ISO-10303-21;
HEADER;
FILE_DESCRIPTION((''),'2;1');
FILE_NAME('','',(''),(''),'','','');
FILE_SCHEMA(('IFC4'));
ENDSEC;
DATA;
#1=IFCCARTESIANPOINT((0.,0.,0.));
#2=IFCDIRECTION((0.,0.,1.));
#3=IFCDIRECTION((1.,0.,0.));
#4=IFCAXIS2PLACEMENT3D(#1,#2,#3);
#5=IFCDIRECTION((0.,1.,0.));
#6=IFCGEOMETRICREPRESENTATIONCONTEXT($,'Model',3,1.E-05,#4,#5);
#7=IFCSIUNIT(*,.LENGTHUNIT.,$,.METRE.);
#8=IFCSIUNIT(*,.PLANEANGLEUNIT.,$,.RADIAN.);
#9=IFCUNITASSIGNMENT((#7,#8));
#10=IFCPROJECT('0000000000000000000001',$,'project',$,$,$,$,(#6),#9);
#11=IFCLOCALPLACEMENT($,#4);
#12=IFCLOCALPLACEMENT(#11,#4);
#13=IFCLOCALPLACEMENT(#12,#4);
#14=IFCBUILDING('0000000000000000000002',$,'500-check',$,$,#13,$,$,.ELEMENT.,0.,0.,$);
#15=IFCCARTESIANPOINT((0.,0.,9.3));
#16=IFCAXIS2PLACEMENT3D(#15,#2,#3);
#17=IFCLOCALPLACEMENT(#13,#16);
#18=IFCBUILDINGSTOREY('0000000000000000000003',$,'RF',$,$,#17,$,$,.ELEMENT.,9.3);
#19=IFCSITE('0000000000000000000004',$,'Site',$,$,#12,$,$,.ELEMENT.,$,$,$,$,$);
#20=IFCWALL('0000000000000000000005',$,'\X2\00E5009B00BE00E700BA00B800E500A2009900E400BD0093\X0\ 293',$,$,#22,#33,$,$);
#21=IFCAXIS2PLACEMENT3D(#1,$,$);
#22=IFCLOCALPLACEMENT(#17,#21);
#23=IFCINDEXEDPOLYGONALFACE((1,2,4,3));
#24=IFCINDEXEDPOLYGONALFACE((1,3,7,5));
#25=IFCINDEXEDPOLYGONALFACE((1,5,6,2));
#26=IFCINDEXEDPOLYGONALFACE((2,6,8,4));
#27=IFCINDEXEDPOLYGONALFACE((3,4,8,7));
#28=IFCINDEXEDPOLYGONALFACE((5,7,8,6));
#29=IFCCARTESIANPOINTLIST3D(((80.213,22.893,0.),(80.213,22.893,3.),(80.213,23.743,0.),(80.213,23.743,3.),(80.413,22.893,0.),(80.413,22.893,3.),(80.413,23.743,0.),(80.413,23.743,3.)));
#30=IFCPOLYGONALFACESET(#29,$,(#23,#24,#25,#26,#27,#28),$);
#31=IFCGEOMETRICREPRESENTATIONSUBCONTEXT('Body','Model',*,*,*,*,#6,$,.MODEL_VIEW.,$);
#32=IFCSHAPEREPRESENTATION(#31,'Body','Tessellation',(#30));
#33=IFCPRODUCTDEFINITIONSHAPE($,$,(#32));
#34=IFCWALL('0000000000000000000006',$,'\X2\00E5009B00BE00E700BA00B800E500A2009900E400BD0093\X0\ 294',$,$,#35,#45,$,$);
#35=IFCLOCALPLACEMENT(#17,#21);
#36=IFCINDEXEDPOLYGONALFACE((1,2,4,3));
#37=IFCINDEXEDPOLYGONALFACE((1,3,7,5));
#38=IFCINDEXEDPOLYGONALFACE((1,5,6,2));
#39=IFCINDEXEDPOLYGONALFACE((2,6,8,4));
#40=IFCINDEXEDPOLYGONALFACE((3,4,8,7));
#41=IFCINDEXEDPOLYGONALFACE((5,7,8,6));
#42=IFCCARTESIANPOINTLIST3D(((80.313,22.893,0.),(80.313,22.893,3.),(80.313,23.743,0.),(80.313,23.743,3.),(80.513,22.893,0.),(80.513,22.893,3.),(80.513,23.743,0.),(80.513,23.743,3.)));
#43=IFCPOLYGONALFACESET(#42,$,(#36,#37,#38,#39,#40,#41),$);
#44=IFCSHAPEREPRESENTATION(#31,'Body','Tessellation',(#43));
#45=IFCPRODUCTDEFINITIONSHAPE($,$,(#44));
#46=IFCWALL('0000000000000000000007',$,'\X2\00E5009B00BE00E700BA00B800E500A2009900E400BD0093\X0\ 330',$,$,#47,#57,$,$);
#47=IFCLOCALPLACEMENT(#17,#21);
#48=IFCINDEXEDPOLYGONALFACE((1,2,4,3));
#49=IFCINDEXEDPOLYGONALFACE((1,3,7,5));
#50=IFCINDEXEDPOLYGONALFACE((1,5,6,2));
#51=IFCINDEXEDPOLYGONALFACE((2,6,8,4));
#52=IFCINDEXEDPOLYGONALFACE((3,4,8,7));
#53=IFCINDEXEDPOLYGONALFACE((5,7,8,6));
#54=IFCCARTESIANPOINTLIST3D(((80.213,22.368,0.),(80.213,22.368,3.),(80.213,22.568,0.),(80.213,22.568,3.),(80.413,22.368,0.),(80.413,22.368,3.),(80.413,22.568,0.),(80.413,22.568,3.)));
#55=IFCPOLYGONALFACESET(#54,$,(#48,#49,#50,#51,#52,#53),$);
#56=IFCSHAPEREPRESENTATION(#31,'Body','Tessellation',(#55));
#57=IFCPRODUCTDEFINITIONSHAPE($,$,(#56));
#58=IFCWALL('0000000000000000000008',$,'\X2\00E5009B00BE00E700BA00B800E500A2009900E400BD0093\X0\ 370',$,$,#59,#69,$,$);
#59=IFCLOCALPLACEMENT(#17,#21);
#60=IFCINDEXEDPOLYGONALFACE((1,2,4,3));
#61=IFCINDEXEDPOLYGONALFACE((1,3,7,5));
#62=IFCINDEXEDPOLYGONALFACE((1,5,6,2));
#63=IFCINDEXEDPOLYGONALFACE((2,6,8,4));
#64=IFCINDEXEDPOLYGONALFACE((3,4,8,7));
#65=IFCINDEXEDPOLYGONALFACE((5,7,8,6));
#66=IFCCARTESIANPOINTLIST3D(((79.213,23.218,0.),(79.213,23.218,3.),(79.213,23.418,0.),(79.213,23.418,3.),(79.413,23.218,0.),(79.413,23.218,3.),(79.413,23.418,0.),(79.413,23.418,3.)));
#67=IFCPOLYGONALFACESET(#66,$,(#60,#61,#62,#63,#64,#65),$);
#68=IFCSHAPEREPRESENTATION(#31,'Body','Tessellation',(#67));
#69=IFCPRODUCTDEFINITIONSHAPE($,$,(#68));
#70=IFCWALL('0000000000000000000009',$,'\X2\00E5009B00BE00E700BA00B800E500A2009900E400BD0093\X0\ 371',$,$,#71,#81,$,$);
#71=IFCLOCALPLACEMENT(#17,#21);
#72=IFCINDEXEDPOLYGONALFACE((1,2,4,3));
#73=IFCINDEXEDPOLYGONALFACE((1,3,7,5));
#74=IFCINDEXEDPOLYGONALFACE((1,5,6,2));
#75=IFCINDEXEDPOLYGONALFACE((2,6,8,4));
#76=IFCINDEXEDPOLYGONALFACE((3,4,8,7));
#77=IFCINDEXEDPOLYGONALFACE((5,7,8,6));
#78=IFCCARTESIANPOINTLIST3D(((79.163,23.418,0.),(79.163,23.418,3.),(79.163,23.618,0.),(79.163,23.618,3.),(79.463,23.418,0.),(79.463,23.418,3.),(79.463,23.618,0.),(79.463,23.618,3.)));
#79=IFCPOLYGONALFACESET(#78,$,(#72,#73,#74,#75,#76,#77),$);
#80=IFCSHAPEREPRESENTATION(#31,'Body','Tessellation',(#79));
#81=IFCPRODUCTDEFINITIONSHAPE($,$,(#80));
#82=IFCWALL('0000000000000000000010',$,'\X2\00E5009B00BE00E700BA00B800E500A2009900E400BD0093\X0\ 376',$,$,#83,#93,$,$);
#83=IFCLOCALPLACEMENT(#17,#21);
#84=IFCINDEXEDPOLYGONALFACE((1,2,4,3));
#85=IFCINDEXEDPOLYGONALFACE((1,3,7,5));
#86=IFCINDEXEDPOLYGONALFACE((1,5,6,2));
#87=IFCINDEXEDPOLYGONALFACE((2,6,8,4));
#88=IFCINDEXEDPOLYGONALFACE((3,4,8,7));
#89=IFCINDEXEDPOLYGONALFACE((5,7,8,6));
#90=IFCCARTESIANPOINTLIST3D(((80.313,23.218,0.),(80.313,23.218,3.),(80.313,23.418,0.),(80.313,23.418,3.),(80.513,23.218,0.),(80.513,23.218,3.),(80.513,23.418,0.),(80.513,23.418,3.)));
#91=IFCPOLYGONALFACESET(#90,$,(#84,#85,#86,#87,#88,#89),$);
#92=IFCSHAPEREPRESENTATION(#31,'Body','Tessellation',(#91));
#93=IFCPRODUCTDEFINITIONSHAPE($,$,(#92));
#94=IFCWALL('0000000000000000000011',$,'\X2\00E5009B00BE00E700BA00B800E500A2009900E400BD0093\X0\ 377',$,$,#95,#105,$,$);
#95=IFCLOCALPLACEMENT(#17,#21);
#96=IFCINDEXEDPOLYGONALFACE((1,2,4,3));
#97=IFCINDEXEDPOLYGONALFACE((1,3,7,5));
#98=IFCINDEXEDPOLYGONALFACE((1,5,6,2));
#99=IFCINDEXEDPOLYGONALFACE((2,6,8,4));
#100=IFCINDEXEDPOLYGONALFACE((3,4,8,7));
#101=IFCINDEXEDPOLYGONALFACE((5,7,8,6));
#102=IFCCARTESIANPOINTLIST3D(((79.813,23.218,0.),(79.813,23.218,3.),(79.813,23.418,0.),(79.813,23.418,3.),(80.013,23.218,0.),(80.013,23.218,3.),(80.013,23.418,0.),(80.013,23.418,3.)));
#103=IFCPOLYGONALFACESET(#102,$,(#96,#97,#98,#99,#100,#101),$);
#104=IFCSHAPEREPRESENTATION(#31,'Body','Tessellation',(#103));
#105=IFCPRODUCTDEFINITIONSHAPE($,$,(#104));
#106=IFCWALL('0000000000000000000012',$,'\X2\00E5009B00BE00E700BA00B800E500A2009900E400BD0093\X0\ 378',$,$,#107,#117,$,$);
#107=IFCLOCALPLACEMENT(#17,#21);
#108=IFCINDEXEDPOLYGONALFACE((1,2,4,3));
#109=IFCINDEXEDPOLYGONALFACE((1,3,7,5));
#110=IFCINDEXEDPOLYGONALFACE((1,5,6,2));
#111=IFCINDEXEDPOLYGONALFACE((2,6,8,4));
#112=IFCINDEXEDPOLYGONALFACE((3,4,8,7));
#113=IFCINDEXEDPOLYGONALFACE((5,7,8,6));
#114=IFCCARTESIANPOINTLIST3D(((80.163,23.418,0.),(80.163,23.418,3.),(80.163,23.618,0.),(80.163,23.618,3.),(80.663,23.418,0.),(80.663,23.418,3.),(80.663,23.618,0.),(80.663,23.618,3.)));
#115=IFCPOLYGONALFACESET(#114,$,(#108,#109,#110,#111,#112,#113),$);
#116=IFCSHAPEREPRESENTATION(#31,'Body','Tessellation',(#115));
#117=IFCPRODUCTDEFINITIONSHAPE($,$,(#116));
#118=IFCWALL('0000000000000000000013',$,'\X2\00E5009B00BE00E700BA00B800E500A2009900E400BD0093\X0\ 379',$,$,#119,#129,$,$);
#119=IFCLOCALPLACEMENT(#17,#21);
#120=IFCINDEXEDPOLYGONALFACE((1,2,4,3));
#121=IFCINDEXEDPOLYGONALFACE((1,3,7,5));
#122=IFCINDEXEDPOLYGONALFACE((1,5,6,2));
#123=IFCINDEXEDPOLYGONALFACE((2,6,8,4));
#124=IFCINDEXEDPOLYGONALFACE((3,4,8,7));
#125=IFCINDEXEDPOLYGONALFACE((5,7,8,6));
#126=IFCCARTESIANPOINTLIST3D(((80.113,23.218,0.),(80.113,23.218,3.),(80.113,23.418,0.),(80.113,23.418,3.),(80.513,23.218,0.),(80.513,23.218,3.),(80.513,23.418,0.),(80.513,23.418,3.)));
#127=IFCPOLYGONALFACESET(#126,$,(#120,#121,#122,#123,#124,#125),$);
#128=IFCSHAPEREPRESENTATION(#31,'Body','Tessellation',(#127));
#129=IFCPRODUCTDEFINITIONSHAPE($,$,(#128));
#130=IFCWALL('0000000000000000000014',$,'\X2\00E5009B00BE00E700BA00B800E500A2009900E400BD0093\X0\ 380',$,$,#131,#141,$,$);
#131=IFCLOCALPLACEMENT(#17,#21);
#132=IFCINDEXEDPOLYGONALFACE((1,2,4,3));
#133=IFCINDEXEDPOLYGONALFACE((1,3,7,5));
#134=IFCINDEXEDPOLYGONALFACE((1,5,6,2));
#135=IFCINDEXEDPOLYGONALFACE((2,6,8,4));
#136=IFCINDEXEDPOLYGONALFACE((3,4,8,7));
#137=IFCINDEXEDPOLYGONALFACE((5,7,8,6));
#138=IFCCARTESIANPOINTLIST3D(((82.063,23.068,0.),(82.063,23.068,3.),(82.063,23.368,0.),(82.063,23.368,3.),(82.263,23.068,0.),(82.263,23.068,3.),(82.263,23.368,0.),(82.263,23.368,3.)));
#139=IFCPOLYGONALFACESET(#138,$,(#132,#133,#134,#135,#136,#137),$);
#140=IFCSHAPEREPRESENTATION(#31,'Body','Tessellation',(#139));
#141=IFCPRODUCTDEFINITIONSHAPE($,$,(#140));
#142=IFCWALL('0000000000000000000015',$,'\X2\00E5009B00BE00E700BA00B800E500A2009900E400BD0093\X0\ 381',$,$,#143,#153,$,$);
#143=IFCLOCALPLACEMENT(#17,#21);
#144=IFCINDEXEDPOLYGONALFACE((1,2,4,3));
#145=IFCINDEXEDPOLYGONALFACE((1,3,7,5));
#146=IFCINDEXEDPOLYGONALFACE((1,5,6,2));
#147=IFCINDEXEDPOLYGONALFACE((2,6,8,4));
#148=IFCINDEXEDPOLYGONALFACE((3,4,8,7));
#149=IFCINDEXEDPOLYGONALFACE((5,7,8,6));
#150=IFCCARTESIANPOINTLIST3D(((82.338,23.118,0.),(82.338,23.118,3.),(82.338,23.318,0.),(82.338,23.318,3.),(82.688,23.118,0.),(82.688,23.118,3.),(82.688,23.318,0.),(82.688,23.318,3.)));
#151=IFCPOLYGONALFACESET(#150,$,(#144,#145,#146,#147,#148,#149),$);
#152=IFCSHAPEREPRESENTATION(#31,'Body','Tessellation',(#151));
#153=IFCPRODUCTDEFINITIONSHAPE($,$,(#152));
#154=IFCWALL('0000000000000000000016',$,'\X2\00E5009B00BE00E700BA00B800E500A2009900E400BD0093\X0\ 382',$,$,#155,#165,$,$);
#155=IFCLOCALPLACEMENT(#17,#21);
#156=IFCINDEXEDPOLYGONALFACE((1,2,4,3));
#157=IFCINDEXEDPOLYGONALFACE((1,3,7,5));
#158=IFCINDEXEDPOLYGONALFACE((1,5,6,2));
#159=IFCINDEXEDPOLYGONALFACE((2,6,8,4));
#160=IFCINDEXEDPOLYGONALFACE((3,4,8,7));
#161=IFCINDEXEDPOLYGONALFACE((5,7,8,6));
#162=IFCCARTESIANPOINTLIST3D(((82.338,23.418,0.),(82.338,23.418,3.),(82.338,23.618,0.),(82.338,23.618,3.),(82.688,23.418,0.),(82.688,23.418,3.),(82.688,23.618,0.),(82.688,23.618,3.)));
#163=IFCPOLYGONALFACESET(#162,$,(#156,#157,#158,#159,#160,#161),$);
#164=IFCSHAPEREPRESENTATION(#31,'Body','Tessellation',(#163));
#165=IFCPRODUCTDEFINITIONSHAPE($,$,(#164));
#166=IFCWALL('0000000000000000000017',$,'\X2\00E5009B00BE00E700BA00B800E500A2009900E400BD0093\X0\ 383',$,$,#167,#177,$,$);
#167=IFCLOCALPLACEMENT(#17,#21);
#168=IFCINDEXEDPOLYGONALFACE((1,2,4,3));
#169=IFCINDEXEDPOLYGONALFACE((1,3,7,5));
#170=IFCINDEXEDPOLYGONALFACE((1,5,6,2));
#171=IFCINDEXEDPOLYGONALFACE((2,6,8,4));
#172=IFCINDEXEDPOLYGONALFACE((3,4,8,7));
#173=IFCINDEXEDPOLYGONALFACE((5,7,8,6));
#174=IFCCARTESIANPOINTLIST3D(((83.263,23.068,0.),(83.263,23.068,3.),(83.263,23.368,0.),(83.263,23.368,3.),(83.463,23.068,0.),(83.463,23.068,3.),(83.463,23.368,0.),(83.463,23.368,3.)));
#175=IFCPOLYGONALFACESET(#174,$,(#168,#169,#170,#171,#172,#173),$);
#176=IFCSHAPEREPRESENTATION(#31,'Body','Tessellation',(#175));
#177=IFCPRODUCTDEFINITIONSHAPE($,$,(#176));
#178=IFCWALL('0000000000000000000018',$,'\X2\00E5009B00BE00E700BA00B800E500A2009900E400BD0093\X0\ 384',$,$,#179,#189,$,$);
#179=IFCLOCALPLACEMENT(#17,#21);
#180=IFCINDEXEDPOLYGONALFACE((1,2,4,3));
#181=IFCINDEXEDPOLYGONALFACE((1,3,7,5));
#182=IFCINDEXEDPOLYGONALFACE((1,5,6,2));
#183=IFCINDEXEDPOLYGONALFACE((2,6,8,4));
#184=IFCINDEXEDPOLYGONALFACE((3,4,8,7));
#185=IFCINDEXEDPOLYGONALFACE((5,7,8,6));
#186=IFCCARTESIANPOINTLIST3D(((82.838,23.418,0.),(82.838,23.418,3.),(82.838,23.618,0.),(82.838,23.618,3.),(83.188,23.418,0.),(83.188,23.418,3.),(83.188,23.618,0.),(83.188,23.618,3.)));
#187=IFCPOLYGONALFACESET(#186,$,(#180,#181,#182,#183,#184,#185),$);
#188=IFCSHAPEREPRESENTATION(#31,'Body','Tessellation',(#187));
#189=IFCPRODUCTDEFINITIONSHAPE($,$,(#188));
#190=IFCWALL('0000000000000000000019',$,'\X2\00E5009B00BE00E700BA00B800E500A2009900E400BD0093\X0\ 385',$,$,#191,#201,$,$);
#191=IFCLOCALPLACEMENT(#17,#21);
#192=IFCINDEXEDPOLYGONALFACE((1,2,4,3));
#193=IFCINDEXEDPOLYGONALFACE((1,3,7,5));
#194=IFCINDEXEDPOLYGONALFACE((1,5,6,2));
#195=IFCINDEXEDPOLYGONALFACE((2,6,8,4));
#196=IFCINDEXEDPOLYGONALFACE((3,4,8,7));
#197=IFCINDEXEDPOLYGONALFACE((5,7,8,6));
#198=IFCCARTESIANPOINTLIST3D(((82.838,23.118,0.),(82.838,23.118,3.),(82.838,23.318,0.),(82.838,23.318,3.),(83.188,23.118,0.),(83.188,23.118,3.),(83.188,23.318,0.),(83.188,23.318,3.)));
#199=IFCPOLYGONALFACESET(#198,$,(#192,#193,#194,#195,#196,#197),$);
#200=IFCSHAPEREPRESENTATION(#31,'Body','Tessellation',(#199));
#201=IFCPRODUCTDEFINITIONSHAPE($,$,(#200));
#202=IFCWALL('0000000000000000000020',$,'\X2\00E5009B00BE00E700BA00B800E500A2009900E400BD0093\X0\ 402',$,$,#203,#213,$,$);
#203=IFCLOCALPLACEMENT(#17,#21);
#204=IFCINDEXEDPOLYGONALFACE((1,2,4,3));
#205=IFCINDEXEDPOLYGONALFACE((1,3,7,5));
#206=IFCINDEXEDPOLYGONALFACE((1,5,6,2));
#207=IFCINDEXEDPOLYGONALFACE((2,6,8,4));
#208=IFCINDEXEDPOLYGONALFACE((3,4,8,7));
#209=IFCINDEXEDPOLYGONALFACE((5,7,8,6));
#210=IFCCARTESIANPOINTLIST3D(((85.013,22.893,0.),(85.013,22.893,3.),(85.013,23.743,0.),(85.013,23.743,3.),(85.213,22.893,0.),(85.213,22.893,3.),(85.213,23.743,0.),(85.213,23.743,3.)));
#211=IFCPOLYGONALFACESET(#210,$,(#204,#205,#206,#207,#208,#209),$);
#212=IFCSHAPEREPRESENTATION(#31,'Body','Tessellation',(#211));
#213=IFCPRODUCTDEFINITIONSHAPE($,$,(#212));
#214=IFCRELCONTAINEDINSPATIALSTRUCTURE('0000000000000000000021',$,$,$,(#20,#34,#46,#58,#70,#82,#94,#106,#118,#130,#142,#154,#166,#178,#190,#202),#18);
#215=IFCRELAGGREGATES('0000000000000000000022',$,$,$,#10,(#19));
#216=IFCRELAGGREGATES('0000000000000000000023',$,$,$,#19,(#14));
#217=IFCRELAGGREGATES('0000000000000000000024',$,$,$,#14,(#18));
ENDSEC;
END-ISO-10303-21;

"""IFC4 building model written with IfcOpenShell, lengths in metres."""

from ifc_helpers import new_model, si_unit, direction, frame, frame_2d, origin_with_axes, place, context, subcontext, project, spatial, rectangle, extrude, element, save


model = new_model("IFC4")

# Units and contexts
model_context = context("Model", 3, precision=1e-05, world=origin_with_axes(), true_north=direction((0.0, 1.0, 0.0)))
body_context = subcontext(model_context, "Body", "Model", "MODEL_VIEW")
ifc_project = project(units=[si_unit("LENGTHUNIT", "METRE"), si_unit("PLANEANGLEUNIT", "RADIAN")], contexts=[model_context])

# Site, building, storey
placement = place(None, origin_with_axes())
site_placement = place(placement, origin_with_axes())
site = spatial("IfcSite", under=ifc_project, at=site_placement, Name="Site", CompositionType="ELEMENT")
building_placement = place(site_placement, origin_with_axes())
building = spatial("IfcBuilding", under=site, at=building_placement, Name="500-check", CompositionType="ELEMENT", ElevationOfRefHeight=0.0, ElevationOfTerrain=0.0)
storey_placement = place(building_placement, frame((0.0, 0.0, 9.3), z_axis=(0.0, 0.0, 1.0), x_axis=(1.0, 0.0, 0.0)))
storey = spatial("IfcBuildingStorey", under=building, at=storey_placement, Name="RF", CompositionType="ELEMENT", Elevation=9.3)

# Walls
for number, where, z_axis, x_axis, name in (
    (1, (80.313, 23.318, 0.0), (0.0, 0.0, 1.0), (0.0, -1.0, 0.0), "å\u009b¾çº¸å¢\u0099ä½\u0093 293"),
    (2, (80.413, 23.318, 0.0), (0.0, 0.0, 1.0), (0.0, -1.0, 0.0), "å\u009b¾çº¸å¢\u0099ä½\u0093 294"),
):
    element("IfcWall", number, at=place(storey_placement, frame(where, z_axis=z_axis, x_axis=x_axis)), inside=storey, Name=name, context=body_context, shape_type="SweptSolid", body=[
        extrude(rectangle(XDim=0.85, YDim=0.2, at=frame_2d((0.0, 0.0), x_axis=(1.0, 0.0, 0.0))), frame((0.0, 0.0, 0.0), z_axis=(0.0, 0.0, 1.0)), (0.0, 0.0, 1.0), 3.0),
    ])
for number, where, z_axis, x_axis, name in (
    (3, (80.313, 22.468, 0.0), (0.0, 0.0, 1.0), (1.0, 0.0, 0.0), "å\u009b¾çº¸å¢\u0099ä½\u0093 330"),
    (4, (79.313, 23.318, 0.0), (0.0, 0.0, 1.0), (-1.0, 0.0, 0.0), "å\u009b¾çº¸å¢\u0099ä½\u0093 370"),
):
    element("IfcWall", number, at=place(storey_placement, frame(where, z_axis=z_axis, x_axis=x_axis)), inside=storey, Name=name, context=body_context, shape_type="SweptSolid", body=[
        extrude(rectangle(XDim=0.2, YDim=0.2, at=frame_2d((0.0, 0.0), x_axis=(1.0, 0.0, 0.0))), frame((0.0, 0.0, 0.0), z_axis=(0.0, 0.0, 1.0)), (0.0, 0.0, 1.0), 3.0),
    ])
wall_1_placement = place(storey_placement, frame((79.313, 23.518, 0.0), z_axis=(0.0, 0.0, 1.0), x_axis=(-1.0, 0.0, 0.0)))
element("IfcWall", 5, at=wall_1_placement, inside=storey, Name="å\u009b¾çº¸å¢\u0099ä½\u0093 371", context=body_context, shape_type="SweptSolid", body=[
    extrude(rectangle(XDim=0.3, YDim=0.2, at=frame_2d((0.0, 0.0), x_axis=(1.0, 0.0, 0.0))), frame((0.0, 0.0, 0.0), z_axis=(0.0, 0.0, 1.0)), (0.0, 0.0, 1.0), 3.0),
])
for number, where, z_axis, x_axis, name in (
    (6, (80.413, 23.318, 0.0), (0.0, 0.0, 1.0), (0.0, 1.0, 0.0), "å\u009b¾çº¸å¢\u0099ä½\u0093 376"),
    (7, (79.913, 23.318, 0.0), (0.0, 0.0, 1.0), (0.0, 1.0, 0.0), "å\u009b¾çº¸å¢\u0099ä½\u0093 377"),
):
    element("IfcWall", number, at=place(storey_placement, frame(where, z_axis=z_axis, x_axis=x_axis)), inside=storey, Name=name, context=body_context, shape_type="SweptSolid", body=[
        extrude(rectangle(XDim=0.2, YDim=0.2, at=frame_2d((0.0, 0.0), x_axis=(1.0, 0.0, 0.0))), frame((0.0, 0.0, 0.0), z_axis=(0.0, 0.0, 1.0)), (0.0, 0.0, 1.0), 3.0),
    ])
wall_2_placement = place(storey_placement, frame((80.413, 23.518, 0.0), z_axis=(0.0, 0.0, 1.0), x_axis=(-1.0, 0.0, 0.0)))
element("IfcWall", 8, at=wall_2_placement, inside=storey, Name="å\u009b¾çº¸å¢\u0099ä½\u0093 378", context=body_context, shape_type="SweptSolid", body=[
    extrude(rectangle(XDim=0.5, YDim=0.2, at=frame_2d((0.0, 0.0), x_axis=(1.0, 0.0, 0.0))), frame((0.0, 0.0, 0.0), z_axis=(0.0, 0.0, 1.0)), (0.0, 0.0, 1.0), 3.0),
])
wall_3_placement = place(storey_placement, frame((80.313, 23.318, 0.0), z_axis=(0.0, 0.0, 1.0), x_axis=(-1.0, 0.0, 0.0)))
element("IfcWall", 9, at=wall_3_placement, inside=storey, Name="å\u009b¾çº¸å¢\u0099ä½\u0093 379", context=body_context, shape_type="SweptSolid", body=[
    extrude(rectangle(XDim=0.4, YDim=0.2, at=frame_2d((0.0, 0.0), x_axis=(1.0, 0.0, 0.0))), frame((0.0, 0.0, 0.0), z_axis=(0.0, 0.0, 1.0)), (0.0, 0.0, 1.0), 3.0),
])
wall_4_placement = place(storey_placement, frame((82.163, 23.218, 0.0), z_axis=(0.0, 0.0, 1.0), x_axis=(0.0, 1.0, 0.0)))
element("IfcWall", 10, at=wall_4_placement, inside=storey, Name="å\u009b¾çº¸å¢\u0099ä½\u0093 380", context=body_context, shape_type="SweptSolid", body=[
    extrude(rectangle(XDim=0.3, YDim=0.2, at=frame_2d((0.0, 0.0), x_axis=(1.0, 0.0, 0.0))), frame((0.0, 0.0, 0.0), z_axis=(0.0, 0.0, 1.0)), (0.0, 0.0, 1.0), 3.0),
])
for number, where, z_axis, x_axis, name in (
    (11, (82.513, 23.218, 0.0), (0.0, 0.0, 1.0), (-1.0, 0.0, 0.0), "å\u009b¾çº¸å¢\u0099ä½\u0093 381"),
    (12, (82.513, 23.518, 0.0), (0.0, 0.0, 1.0), (-1.0, 0.0, 0.0), "å\u009b¾çº¸å¢\u0099ä½\u0093 382"),
):
    element("IfcWall", number, at=place(storey_placement, frame(where, z_axis=z_axis, x_axis=x_axis)), inside=storey, Name=name, context=body_context, shape_type="SweptSolid", body=[
        extrude(rectangle(XDim=0.35, YDim=0.2, at=frame_2d((0.0, 0.0), x_axis=(1.0, 0.0, 0.0))), frame((0.0, 0.0, 0.0), z_axis=(0.0, 0.0, 1.0)), (0.0, 0.0, 1.0), 3.0),
    ])
wall_5_placement = place(storey_placement, frame((83.363, 23.218, 0.0), z_axis=(0.0, 0.0, 1.0), x_axis=(0.0, 1.0, 0.0)))
element("IfcWall", 13, at=wall_5_placement, inside=storey, Name="å\u009b¾çº¸å¢\u0099ä½\u0093 383", context=body_context, shape_type="SweptSolid", body=[
    extrude(rectangle(XDim=0.3, YDim=0.2, at=frame_2d((0.0, 0.0), x_axis=(1.0, 0.0, 0.0))), frame((0.0, 0.0, 0.0), z_axis=(0.0, 0.0, 1.0)), (0.0, 0.0, 1.0), 3.0),
])
for number, where, z_axis, x_axis, name in (
    (14, (83.013, 23.518, 0.0), (0.0, 0.0, 1.0), (1.0, 0.0, 0.0), "å\u009b¾çº¸å¢\u0099ä½\u0093 384"),
    (15, (83.013, 23.218, 0.0), (0.0, 0.0, 1.0), (1.0, 0.0, 0.0), "å\u009b¾çº¸å¢\u0099ä½\u0093 385"),
):
    element("IfcWall", number, at=place(storey_placement, frame(where, z_axis=z_axis, x_axis=x_axis)), inside=storey, Name=name, context=body_context, shape_type="SweptSolid", body=[
        extrude(rectangle(XDim=0.35, YDim=0.2, at=frame_2d((0.0, 0.0), x_axis=(1.0, 0.0, 0.0))), frame((0.0, 0.0, 0.0), z_axis=(0.0, 0.0, 1.0)), (0.0, 0.0, 1.0), 3.0),
    ])
for number, where, z_axis, x_axis, name in (
    (16, (85.113, 23.318, 0.0), (0.0, 0.0, 1.0), (0.0, -1.0, 0.0), "å\u009b¾çº¸å¢\u0099ä½\u0093 402"),
):
    element("IfcWall", number, at=place(storey_placement, frame(where, z_axis=z_axis, x_axis=x_axis)), inside=storey, Name=name, context=body_context, shape_type="SweptSolid", body=[
        extrude(rectangle(XDim=0.85, YDim=0.2, at=frame_2d((0.0, 0.0), x_axis=(1.0, 0.0, 0.0))), frame((0.0, 0.0, 0.0), z_axis=(0.0, 0.0, 1.0)), (0.0, 0.0, 1.0), 3.0),
    ])

save(model, "model.ifc")
